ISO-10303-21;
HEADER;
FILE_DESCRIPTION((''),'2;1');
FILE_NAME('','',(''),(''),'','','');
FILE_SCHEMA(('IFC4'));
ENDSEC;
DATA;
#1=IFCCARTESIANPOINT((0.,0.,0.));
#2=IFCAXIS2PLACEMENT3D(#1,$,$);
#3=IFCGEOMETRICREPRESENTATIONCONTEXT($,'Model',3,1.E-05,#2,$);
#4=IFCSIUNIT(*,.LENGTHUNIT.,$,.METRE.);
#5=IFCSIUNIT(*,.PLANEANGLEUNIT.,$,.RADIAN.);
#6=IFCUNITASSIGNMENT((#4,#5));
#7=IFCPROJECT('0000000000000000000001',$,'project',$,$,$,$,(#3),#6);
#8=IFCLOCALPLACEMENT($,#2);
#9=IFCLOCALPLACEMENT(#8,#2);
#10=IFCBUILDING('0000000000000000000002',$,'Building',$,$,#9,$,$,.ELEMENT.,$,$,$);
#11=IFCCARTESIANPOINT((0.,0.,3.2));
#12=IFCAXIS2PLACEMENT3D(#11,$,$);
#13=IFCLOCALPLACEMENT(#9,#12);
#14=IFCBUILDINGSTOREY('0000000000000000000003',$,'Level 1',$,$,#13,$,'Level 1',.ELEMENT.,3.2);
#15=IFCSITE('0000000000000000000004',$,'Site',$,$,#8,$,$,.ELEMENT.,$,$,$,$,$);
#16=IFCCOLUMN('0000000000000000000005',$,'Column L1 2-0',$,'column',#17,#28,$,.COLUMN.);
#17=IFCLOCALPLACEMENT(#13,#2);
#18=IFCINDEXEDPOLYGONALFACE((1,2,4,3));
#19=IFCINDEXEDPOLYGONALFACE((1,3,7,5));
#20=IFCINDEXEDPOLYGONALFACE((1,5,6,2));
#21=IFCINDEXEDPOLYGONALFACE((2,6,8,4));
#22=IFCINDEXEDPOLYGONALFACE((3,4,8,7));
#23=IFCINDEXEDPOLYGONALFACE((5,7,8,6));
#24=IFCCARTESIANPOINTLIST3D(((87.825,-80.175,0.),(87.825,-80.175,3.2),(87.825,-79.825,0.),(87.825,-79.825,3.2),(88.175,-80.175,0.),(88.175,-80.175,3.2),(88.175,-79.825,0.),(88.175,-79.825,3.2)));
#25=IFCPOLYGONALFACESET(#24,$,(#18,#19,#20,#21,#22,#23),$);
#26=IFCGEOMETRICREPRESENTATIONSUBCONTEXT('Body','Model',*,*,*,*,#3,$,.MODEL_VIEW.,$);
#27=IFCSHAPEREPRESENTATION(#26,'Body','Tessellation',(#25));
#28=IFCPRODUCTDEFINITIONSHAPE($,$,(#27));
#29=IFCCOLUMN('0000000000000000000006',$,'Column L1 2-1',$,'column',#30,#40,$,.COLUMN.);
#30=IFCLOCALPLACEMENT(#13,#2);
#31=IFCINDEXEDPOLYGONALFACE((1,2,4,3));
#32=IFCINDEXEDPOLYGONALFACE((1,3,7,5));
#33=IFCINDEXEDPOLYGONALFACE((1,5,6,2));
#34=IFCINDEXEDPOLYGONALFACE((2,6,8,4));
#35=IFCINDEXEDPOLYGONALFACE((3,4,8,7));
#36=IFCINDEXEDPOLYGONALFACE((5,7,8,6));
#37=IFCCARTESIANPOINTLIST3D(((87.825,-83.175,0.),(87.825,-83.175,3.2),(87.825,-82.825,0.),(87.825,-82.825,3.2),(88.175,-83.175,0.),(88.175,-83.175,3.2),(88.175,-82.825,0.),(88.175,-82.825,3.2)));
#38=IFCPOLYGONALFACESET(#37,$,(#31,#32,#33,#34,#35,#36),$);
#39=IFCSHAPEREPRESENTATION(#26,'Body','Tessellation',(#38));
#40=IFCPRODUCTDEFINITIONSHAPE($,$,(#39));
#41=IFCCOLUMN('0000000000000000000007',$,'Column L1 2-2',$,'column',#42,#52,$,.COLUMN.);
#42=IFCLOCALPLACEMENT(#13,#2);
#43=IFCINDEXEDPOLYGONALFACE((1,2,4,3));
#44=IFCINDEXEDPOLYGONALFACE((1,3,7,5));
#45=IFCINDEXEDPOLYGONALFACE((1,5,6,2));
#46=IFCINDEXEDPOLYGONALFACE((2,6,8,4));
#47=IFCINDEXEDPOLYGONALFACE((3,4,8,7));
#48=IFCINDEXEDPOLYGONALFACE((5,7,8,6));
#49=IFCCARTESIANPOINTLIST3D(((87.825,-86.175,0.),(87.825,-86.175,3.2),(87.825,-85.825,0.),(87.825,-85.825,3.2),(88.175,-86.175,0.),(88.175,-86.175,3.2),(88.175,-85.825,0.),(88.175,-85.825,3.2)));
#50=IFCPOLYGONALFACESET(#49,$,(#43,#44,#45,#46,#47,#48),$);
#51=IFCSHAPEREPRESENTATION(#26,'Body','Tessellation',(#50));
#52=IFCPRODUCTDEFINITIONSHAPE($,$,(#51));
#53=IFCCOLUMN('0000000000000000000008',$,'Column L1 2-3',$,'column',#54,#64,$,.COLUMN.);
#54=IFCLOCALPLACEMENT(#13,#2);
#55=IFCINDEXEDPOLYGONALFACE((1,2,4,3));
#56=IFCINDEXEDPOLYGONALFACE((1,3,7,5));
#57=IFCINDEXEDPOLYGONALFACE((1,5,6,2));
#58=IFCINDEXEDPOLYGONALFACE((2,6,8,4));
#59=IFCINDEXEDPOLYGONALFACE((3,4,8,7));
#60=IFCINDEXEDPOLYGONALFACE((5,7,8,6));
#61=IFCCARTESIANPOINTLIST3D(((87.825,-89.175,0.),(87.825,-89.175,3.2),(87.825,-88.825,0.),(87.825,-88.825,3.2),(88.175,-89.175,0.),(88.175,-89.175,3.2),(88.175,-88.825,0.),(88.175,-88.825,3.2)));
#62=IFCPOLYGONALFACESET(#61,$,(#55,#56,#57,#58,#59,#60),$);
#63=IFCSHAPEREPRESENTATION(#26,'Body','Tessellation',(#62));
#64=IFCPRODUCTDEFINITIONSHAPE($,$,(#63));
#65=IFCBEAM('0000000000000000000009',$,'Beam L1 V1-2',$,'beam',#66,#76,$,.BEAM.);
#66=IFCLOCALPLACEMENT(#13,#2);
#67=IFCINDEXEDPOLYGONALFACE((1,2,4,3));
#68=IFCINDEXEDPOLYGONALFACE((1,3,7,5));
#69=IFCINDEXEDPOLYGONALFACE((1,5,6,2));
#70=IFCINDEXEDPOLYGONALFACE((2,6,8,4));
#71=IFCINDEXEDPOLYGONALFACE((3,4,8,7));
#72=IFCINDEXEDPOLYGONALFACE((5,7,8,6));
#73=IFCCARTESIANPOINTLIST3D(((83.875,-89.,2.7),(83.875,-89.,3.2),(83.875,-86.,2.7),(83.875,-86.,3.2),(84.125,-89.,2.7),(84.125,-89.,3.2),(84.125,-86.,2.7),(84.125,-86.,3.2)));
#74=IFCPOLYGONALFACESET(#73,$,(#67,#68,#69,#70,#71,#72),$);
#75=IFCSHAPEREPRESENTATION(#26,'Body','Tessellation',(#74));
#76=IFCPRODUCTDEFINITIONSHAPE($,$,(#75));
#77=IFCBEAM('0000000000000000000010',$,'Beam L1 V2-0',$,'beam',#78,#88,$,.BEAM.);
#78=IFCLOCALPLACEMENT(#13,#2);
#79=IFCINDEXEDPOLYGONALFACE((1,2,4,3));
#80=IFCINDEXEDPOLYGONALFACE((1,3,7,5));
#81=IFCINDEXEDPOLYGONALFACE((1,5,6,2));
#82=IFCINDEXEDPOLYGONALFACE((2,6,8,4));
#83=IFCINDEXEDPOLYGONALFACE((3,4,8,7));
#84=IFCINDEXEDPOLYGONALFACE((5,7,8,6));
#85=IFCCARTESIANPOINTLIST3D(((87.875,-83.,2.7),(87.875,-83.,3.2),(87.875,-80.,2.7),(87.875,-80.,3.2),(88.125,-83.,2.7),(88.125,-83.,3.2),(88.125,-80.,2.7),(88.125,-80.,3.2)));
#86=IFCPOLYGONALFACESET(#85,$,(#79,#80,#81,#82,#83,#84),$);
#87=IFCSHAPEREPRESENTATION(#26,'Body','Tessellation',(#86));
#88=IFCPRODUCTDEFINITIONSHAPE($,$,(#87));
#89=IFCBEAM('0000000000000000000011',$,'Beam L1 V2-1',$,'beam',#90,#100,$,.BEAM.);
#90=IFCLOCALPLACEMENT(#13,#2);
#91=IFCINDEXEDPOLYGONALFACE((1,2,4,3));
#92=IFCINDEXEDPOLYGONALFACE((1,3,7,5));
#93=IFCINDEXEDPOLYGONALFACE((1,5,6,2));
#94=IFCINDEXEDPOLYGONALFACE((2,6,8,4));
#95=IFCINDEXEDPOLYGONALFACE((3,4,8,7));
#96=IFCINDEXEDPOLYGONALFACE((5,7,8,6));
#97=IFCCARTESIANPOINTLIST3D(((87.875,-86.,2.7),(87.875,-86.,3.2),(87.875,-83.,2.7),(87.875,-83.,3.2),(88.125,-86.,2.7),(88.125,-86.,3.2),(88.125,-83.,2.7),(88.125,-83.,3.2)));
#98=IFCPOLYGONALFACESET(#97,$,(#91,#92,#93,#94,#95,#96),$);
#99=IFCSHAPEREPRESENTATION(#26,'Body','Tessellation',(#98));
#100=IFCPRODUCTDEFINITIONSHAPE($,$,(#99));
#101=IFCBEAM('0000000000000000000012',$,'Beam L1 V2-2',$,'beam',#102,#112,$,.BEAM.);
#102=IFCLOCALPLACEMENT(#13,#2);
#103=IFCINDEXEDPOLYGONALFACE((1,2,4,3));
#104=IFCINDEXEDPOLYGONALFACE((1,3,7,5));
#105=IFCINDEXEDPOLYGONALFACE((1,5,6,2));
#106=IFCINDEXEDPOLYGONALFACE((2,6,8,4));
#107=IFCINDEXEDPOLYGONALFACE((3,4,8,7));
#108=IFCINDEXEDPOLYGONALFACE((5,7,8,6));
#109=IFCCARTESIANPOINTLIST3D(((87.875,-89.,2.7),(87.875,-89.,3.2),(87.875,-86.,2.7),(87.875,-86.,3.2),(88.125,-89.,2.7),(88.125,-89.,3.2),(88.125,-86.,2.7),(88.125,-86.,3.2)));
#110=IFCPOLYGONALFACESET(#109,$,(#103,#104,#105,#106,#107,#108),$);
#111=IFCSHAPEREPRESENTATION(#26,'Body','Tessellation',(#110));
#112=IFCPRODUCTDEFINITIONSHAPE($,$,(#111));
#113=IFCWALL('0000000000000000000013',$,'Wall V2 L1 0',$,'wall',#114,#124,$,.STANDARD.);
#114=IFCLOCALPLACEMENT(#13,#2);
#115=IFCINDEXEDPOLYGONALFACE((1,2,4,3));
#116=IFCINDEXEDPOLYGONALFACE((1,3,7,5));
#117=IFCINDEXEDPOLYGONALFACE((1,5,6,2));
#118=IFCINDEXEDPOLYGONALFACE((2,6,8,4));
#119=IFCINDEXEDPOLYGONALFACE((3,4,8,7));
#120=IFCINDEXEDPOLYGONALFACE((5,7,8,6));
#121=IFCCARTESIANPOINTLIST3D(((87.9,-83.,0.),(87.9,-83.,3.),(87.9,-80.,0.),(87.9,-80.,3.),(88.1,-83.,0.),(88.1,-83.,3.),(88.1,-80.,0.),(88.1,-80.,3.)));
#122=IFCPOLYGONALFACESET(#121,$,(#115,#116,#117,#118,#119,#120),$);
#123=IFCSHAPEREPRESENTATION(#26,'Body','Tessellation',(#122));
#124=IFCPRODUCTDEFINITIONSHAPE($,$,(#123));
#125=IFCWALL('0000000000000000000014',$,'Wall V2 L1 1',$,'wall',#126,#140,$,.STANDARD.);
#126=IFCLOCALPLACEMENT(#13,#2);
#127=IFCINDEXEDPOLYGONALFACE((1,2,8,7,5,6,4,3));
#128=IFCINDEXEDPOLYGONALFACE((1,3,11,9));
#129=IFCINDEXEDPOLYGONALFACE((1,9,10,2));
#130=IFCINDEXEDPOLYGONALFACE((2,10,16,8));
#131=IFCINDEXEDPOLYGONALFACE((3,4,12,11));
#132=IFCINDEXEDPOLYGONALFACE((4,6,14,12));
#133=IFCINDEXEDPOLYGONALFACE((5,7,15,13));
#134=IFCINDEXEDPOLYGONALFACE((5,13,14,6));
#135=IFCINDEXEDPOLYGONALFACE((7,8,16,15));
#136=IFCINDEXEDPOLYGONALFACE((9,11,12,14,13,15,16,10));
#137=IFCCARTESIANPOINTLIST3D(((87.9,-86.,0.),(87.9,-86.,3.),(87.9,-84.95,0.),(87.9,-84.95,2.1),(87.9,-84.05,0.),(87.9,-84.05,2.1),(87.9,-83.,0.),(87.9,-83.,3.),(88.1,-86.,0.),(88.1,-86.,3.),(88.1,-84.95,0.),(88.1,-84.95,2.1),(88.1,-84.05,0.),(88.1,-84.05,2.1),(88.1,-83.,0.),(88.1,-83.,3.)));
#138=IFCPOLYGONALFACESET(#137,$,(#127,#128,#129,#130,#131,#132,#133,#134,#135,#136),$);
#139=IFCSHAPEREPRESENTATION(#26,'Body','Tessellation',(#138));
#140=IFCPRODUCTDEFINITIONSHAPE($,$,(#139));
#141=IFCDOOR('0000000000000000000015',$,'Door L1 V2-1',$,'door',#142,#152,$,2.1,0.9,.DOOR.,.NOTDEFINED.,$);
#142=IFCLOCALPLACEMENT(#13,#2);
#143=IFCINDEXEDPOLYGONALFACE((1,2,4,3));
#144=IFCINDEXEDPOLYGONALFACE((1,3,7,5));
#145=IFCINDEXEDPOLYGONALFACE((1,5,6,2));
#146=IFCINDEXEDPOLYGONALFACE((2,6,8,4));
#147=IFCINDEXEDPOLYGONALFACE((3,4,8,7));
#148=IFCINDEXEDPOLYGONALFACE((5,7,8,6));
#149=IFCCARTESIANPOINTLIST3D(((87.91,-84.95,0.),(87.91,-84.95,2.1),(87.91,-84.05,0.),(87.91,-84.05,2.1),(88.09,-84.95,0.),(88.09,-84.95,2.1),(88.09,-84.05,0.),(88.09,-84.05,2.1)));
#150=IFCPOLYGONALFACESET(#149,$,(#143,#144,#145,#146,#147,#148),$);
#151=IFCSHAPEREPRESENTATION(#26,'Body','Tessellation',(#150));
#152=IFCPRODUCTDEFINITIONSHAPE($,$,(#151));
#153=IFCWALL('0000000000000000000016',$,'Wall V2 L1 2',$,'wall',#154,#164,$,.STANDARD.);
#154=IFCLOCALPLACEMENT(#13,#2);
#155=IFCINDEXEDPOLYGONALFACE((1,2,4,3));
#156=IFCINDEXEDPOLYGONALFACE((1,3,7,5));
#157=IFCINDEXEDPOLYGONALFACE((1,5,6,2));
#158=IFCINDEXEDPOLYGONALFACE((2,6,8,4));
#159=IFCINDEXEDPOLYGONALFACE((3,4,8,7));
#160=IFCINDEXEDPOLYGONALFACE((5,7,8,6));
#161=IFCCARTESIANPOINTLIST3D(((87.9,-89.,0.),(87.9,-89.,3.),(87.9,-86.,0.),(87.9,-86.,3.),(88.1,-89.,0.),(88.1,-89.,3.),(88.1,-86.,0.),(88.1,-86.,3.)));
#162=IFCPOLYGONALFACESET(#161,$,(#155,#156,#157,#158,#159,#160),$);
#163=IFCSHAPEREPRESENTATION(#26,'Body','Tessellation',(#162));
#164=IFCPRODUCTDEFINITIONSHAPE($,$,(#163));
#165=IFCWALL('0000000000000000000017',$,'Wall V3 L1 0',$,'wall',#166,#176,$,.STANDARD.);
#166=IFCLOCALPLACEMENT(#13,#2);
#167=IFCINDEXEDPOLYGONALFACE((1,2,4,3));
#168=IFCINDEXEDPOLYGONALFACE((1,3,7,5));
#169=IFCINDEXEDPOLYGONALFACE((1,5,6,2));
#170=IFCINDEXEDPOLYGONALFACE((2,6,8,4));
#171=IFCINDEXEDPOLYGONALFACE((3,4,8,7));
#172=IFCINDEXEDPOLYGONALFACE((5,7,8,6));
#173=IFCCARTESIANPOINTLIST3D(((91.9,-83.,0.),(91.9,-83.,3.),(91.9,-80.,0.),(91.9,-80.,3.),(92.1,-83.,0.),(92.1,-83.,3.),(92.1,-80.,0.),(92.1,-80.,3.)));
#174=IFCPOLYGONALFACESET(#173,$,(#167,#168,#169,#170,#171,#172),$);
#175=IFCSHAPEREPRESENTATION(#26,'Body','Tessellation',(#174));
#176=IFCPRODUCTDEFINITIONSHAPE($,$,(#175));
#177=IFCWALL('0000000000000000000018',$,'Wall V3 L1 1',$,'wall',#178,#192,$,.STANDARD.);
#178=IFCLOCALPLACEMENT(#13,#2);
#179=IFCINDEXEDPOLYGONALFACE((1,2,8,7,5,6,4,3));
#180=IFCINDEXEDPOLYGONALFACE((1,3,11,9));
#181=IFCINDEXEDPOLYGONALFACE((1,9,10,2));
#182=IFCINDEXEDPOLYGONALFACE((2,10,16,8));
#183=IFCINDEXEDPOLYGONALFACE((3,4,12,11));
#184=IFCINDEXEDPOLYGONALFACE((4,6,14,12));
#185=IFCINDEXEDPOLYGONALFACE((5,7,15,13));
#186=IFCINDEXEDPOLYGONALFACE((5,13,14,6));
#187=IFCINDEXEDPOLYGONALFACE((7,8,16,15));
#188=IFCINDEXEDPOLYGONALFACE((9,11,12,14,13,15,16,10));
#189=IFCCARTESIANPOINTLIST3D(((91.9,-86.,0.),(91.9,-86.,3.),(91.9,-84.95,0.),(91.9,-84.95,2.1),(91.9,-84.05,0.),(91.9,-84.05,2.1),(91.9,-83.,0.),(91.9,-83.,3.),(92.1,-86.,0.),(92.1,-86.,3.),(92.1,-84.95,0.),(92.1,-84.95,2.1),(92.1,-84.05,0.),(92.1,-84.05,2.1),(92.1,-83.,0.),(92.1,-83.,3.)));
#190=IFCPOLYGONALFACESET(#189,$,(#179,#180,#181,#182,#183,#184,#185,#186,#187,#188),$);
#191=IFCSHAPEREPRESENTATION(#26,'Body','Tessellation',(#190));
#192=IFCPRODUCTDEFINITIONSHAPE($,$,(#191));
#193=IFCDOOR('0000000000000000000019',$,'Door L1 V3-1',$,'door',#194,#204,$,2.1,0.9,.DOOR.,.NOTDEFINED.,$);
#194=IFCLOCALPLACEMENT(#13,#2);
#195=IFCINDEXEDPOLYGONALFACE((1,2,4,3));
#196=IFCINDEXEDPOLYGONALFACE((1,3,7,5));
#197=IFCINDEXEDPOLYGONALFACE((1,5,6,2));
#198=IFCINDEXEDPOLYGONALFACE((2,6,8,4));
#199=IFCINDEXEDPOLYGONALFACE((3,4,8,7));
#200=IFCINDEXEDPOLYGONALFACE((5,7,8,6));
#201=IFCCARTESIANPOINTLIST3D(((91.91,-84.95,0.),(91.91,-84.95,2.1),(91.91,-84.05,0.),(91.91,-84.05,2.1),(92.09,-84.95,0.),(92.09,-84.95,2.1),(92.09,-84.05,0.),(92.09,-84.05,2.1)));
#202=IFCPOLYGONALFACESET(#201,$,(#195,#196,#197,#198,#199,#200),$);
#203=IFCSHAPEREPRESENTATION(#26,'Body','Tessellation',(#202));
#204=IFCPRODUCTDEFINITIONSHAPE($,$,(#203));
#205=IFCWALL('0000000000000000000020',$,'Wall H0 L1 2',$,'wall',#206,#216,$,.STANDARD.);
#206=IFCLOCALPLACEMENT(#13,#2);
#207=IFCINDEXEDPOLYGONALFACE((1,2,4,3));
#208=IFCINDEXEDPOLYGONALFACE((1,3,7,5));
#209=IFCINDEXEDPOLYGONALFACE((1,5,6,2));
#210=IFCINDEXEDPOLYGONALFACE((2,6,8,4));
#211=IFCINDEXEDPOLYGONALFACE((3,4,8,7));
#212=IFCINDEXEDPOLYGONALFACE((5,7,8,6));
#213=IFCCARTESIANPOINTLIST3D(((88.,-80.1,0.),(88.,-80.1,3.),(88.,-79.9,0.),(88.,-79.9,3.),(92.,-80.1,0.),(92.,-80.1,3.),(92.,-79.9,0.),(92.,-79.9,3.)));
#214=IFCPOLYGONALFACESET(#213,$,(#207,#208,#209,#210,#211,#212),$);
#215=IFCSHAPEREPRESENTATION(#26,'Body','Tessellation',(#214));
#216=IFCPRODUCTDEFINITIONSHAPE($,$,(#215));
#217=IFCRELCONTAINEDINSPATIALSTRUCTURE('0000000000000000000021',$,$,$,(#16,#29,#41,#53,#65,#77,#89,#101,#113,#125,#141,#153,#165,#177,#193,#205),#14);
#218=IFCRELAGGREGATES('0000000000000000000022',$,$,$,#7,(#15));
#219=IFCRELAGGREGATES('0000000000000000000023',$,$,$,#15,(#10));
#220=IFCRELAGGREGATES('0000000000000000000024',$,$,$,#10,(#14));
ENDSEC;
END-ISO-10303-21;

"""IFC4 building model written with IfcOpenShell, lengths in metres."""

from ifc_helpers import new_model, si_unit, frame, frame_2d, origin, origin_2d, place, context, subcontext, project, spatial, rectangle, extrude, element, fill, save


model = new_model("IFC4")

# Units and contexts
model_context = context("Model", 3, precision=1e-05, world=origin())
body_context = subcontext(model_context, "Body", "Model", "MODEL_VIEW")
ifc_project = project(units=[si_unit("LENGTHUNIT", "METRE"), si_unit("PLANEANGLEUNIT", "RADIAN")], contexts=[model_context])

# Site, building, storey
site_placement = place(None, origin())
site = spatial("IfcSite", under=ifc_project, at=site_placement, Name="Site", CompositionType="ELEMENT")
building_placement = place(site_placement, origin())
building = spatial("IfcBuilding", under=site, at=building_placement, Name="Building", CompositionType="ELEMENT")
storey_placement = place(building_placement, frame((0.0, 0.0, 3.2)))
storey = spatial("IfcBuildingStorey", under=building, at=storey_placement, Name="Level 1", LongName="Level 1", CompositionType="ELEMENT", Elevation=3.2)

# Columns
for number, where, name in (
    (1, (88.0, -80.0, 0.0), "Column L1 2-0"),
    (2, (88.0, -83.0, 0.0), "Column L1 2-1"),
    (3, (88.0, -86.0, 0.0), "Column L1 2-2"),
    (4, (88.0, -89.0, 0.0), "Column L1 2-3"),
):
    element("IfcColumn", number, at=place(storey_placement, frame(where)), inside=storey, Name=name, ObjectType="column", PredefinedType="COLUMN", context=body_context, shape_type="SweptSolid", body=[
        extrude(rectangle(XDim=0.35, YDim=0.35, at=origin_2d()), origin(), (0.0, 0.0, 1.0), 3.2),
    ])

# Beams
for number, where, z_axis, x_axis, name in (
    (5, (84.0, -86.0, 2.95), (0.0, -1.0, 0.0), (0.0, 0.0, 1.0), "Beam L1 V1-2"),
    (6, (88.0, -80.0, 2.95), (0.0, -1.0, 0.0), (0.0, 0.0, 1.0), "Beam L1 V2-0"),
    (7, (88.0, -83.0, 2.95), (0.0, -1.0, 0.0), (0.0, 0.0, 1.0), "Beam L1 V2-1"),
    (8, (88.0, -86.0, 2.95), (0.0, -1.0, 0.0), (0.0, 0.0, 1.0), "Beam L1 V2-2"),
):
    element("IfcBeam", number, at=place(storey_placement, frame(where, z_axis=z_axis, x_axis=x_axis)), inside=storey, Name=name, ObjectType="beam", PredefinedType="BEAM", context=body_context, shape_type="SweptSolid", body=[
        extrude(rectangle(XDim=0.5, YDim=0.25, at=origin_2d()), origin(), (0.0, 0.0, 1.0), 3.0),
    ])

# Wall
wall_1_placement = place(storey_placement, frame((88.0, -80.0, 0.0), z_axis=(0.0, 0.0, 1.0), x_axis=(0.0, -1.0, 0.0)))
element("IfcWall", 9, at=wall_1_placement, inside=storey, Name="Wall V2 L1 0", ObjectType="wall", PredefinedType="STANDARD", context=body_context, shape_type="SweptSolid", body=[
    extrude(rectangle(XDim=3.0, YDim=0.2, at=frame_2d((1.5, 0.0))), origin(), (0.0, 0.0, 1.0), 3.0),
])

# Wall, opening, door
wall_2_placement = place(storey_placement, frame((88.0, -83.0, 0.0), z_axis=(0.0, 0.0, 1.0), x_axis=(0.0, -1.0, 0.0)))
wall_2 = element("IfcWall", 10, at=wall_2_placement, inside=storey, Name="Wall V2 L1 1", ObjectType="wall", PredefinedType="STANDARD", context=body_context, shape_type="SweptSolid", body=[
    extrude(rectangle(XDim=3.0, YDim=0.2, at=frame_2d((1.5, 0.0))), origin(), (0.0, 0.0, 1.0), 3.0),
])
opening_1_placement = place(storey_placement, frame((88.0, -84.5, 0.0), z_axis=(0.0, 0.0, 1.0), x_axis=(0.0, -1.0, 0.0)))
opening_1 = element("IfcOpeningElement", 11, at=opening_1_placement, cuts=wall_2, ObjectType="Opening", PredefinedType="OPENING", context=body_context, shape_type="SweptSolid", body=[
    extrude(rectangle(XDim=0.9, YDim=0.22, at=origin_2d()), origin(), (0.0, 0.0, 1.0), 2.1),
])
door_1_placement = place(storey_placement, frame((88.0, -84.5, 0.0), z_axis=(0.0, 0.0, 1.0), x_axis=(0.0, -1.0, 0.0)))
door_1 = element("IfcDoor", 12, at=door_1_placement, inside=storey, Name="Door L1 V2-1", ObjectType="door", OperationType="NOTDEFINED", OverallHeight=2.1, OverallWidth=0.9, PredefinedType="DOOR", context=body_context, shape_type="SweptSolid", body=[
    extrude(rectangle(XDim=0.9, YDim=0.18, at=origin_2d()), origin(), (0.0, 0.0, 1.0), 2.1),
])
fill(opening_1, door_1)

# Walls
for number, where, z_axis, x_axis, name in (
    (13, (88.0, -86.0, 0.0), (0.0, 0.0, 1.0), (0.0, -1.0, 0.0), "Wall V2 L1 2"),
    (14, (92.0, -80.0, 0.0), (0.0, 0.0, 1.0), (0.0, -1.0, 0.0), "Wall V3 L1 0"),
):
    element("IfcWall", number, at=place(storey_placement, frame(where, z_axis=z_axis, x_axis=x_axis)), inside=storey, Name=name, ObjectType="wall", PredefinedType="STANDARD", context=body_context, shape_type="SweptSolid", body=[
        extrude(rectangle(XDim=3.0, YDim=0.2, at=frame_2d((1.5, 0.0))), origin(), (0.0, 0.0, 1.0), 3.0),
    ])

# Wall, opening, door
wall_3_placement = place(storey_placement, frame((92.0, -83.0, 0.0), z_axis=(0.0, 0.0, 1.0), x_axis=(0.0, -1.0, 0.0)))
wall_3 = element("IfcWall", 15, at=wall_3_placement, inside=storey, Name="Wall V3 L1 1", ObjectType="wall", PredefinedType="STANDARD", context=body_context, shape_type="SweptSolid", body=[
    extrude(rectangle(XDim=3.0, YDim=0.2, at=frame_2d((1.5, 0.0))), origin(), (0.0, 0.0, 1.0), 3.0),
])
opening_2_placement = place(storey_placement, frame((92.0, -84.5, 0.0), z_axis=(0.0, 0.0, 1.0), x_axis=(0.0, -1.0, 0.0)))
opening_2 = element("IfcOpeningElement", 16, at=opening_2_placement, cuts=wall_3, ObjectType="Opening", PredefinedType="OPENING", context=body_context, shape_type="SweptSolid", body=[
    extrude(rectangle(XDim=0.9, YDim=0.22, at=origin_2d()), origin(), (0.0, 0.0, 1.0), 2.1),
])
door_2_placement = place(storey_placement, frame((92.0, -84.5, 0.0), z_axis=(0.0, 0.0, 1.0), x_axis=(0.0, -1.0, 0.0)))
door_2 = element("IfcDoor", 17, at=door_2_placement, inside=storey, Name="Door L1 V3-1", ObjectType="door", OperationType="NOTDEFINED", OverallHeight=2.1, OverallWidth=0.9, PredefinedType="DOOR", context=body_context, shape_type="SweptSolid", body=[
    extrude(rectangle(XDim=0.9, YDim=0.18, at=origin_2d()), origin(), (0.0, 0.0, 1.0), 2.1),
])
fill(opening_2, door_2)

# Wall
wall_4_placement = place(storey_placement, frame((88.0, -80.0, 0.0), z_axis=(0.0, 0.0, 1.0), x_axis=(1.0, 0.0, 0.0)))
element("IfcWall", 18, at=wall_4_placement, inside=storey, Name="Wall H0 L1 2", ObjectType="wall", PredefinedType="STANDARD", context=body_context, shape_type="SweptSolid", body=[
    extrude(rectangle(XDim=4.0, YDim=0.2, at=frame_2d((2.0, 0.0))), origin(), (0.0, 0.0, 1.0), 3.0),
])

save(model, "model.ifc")
